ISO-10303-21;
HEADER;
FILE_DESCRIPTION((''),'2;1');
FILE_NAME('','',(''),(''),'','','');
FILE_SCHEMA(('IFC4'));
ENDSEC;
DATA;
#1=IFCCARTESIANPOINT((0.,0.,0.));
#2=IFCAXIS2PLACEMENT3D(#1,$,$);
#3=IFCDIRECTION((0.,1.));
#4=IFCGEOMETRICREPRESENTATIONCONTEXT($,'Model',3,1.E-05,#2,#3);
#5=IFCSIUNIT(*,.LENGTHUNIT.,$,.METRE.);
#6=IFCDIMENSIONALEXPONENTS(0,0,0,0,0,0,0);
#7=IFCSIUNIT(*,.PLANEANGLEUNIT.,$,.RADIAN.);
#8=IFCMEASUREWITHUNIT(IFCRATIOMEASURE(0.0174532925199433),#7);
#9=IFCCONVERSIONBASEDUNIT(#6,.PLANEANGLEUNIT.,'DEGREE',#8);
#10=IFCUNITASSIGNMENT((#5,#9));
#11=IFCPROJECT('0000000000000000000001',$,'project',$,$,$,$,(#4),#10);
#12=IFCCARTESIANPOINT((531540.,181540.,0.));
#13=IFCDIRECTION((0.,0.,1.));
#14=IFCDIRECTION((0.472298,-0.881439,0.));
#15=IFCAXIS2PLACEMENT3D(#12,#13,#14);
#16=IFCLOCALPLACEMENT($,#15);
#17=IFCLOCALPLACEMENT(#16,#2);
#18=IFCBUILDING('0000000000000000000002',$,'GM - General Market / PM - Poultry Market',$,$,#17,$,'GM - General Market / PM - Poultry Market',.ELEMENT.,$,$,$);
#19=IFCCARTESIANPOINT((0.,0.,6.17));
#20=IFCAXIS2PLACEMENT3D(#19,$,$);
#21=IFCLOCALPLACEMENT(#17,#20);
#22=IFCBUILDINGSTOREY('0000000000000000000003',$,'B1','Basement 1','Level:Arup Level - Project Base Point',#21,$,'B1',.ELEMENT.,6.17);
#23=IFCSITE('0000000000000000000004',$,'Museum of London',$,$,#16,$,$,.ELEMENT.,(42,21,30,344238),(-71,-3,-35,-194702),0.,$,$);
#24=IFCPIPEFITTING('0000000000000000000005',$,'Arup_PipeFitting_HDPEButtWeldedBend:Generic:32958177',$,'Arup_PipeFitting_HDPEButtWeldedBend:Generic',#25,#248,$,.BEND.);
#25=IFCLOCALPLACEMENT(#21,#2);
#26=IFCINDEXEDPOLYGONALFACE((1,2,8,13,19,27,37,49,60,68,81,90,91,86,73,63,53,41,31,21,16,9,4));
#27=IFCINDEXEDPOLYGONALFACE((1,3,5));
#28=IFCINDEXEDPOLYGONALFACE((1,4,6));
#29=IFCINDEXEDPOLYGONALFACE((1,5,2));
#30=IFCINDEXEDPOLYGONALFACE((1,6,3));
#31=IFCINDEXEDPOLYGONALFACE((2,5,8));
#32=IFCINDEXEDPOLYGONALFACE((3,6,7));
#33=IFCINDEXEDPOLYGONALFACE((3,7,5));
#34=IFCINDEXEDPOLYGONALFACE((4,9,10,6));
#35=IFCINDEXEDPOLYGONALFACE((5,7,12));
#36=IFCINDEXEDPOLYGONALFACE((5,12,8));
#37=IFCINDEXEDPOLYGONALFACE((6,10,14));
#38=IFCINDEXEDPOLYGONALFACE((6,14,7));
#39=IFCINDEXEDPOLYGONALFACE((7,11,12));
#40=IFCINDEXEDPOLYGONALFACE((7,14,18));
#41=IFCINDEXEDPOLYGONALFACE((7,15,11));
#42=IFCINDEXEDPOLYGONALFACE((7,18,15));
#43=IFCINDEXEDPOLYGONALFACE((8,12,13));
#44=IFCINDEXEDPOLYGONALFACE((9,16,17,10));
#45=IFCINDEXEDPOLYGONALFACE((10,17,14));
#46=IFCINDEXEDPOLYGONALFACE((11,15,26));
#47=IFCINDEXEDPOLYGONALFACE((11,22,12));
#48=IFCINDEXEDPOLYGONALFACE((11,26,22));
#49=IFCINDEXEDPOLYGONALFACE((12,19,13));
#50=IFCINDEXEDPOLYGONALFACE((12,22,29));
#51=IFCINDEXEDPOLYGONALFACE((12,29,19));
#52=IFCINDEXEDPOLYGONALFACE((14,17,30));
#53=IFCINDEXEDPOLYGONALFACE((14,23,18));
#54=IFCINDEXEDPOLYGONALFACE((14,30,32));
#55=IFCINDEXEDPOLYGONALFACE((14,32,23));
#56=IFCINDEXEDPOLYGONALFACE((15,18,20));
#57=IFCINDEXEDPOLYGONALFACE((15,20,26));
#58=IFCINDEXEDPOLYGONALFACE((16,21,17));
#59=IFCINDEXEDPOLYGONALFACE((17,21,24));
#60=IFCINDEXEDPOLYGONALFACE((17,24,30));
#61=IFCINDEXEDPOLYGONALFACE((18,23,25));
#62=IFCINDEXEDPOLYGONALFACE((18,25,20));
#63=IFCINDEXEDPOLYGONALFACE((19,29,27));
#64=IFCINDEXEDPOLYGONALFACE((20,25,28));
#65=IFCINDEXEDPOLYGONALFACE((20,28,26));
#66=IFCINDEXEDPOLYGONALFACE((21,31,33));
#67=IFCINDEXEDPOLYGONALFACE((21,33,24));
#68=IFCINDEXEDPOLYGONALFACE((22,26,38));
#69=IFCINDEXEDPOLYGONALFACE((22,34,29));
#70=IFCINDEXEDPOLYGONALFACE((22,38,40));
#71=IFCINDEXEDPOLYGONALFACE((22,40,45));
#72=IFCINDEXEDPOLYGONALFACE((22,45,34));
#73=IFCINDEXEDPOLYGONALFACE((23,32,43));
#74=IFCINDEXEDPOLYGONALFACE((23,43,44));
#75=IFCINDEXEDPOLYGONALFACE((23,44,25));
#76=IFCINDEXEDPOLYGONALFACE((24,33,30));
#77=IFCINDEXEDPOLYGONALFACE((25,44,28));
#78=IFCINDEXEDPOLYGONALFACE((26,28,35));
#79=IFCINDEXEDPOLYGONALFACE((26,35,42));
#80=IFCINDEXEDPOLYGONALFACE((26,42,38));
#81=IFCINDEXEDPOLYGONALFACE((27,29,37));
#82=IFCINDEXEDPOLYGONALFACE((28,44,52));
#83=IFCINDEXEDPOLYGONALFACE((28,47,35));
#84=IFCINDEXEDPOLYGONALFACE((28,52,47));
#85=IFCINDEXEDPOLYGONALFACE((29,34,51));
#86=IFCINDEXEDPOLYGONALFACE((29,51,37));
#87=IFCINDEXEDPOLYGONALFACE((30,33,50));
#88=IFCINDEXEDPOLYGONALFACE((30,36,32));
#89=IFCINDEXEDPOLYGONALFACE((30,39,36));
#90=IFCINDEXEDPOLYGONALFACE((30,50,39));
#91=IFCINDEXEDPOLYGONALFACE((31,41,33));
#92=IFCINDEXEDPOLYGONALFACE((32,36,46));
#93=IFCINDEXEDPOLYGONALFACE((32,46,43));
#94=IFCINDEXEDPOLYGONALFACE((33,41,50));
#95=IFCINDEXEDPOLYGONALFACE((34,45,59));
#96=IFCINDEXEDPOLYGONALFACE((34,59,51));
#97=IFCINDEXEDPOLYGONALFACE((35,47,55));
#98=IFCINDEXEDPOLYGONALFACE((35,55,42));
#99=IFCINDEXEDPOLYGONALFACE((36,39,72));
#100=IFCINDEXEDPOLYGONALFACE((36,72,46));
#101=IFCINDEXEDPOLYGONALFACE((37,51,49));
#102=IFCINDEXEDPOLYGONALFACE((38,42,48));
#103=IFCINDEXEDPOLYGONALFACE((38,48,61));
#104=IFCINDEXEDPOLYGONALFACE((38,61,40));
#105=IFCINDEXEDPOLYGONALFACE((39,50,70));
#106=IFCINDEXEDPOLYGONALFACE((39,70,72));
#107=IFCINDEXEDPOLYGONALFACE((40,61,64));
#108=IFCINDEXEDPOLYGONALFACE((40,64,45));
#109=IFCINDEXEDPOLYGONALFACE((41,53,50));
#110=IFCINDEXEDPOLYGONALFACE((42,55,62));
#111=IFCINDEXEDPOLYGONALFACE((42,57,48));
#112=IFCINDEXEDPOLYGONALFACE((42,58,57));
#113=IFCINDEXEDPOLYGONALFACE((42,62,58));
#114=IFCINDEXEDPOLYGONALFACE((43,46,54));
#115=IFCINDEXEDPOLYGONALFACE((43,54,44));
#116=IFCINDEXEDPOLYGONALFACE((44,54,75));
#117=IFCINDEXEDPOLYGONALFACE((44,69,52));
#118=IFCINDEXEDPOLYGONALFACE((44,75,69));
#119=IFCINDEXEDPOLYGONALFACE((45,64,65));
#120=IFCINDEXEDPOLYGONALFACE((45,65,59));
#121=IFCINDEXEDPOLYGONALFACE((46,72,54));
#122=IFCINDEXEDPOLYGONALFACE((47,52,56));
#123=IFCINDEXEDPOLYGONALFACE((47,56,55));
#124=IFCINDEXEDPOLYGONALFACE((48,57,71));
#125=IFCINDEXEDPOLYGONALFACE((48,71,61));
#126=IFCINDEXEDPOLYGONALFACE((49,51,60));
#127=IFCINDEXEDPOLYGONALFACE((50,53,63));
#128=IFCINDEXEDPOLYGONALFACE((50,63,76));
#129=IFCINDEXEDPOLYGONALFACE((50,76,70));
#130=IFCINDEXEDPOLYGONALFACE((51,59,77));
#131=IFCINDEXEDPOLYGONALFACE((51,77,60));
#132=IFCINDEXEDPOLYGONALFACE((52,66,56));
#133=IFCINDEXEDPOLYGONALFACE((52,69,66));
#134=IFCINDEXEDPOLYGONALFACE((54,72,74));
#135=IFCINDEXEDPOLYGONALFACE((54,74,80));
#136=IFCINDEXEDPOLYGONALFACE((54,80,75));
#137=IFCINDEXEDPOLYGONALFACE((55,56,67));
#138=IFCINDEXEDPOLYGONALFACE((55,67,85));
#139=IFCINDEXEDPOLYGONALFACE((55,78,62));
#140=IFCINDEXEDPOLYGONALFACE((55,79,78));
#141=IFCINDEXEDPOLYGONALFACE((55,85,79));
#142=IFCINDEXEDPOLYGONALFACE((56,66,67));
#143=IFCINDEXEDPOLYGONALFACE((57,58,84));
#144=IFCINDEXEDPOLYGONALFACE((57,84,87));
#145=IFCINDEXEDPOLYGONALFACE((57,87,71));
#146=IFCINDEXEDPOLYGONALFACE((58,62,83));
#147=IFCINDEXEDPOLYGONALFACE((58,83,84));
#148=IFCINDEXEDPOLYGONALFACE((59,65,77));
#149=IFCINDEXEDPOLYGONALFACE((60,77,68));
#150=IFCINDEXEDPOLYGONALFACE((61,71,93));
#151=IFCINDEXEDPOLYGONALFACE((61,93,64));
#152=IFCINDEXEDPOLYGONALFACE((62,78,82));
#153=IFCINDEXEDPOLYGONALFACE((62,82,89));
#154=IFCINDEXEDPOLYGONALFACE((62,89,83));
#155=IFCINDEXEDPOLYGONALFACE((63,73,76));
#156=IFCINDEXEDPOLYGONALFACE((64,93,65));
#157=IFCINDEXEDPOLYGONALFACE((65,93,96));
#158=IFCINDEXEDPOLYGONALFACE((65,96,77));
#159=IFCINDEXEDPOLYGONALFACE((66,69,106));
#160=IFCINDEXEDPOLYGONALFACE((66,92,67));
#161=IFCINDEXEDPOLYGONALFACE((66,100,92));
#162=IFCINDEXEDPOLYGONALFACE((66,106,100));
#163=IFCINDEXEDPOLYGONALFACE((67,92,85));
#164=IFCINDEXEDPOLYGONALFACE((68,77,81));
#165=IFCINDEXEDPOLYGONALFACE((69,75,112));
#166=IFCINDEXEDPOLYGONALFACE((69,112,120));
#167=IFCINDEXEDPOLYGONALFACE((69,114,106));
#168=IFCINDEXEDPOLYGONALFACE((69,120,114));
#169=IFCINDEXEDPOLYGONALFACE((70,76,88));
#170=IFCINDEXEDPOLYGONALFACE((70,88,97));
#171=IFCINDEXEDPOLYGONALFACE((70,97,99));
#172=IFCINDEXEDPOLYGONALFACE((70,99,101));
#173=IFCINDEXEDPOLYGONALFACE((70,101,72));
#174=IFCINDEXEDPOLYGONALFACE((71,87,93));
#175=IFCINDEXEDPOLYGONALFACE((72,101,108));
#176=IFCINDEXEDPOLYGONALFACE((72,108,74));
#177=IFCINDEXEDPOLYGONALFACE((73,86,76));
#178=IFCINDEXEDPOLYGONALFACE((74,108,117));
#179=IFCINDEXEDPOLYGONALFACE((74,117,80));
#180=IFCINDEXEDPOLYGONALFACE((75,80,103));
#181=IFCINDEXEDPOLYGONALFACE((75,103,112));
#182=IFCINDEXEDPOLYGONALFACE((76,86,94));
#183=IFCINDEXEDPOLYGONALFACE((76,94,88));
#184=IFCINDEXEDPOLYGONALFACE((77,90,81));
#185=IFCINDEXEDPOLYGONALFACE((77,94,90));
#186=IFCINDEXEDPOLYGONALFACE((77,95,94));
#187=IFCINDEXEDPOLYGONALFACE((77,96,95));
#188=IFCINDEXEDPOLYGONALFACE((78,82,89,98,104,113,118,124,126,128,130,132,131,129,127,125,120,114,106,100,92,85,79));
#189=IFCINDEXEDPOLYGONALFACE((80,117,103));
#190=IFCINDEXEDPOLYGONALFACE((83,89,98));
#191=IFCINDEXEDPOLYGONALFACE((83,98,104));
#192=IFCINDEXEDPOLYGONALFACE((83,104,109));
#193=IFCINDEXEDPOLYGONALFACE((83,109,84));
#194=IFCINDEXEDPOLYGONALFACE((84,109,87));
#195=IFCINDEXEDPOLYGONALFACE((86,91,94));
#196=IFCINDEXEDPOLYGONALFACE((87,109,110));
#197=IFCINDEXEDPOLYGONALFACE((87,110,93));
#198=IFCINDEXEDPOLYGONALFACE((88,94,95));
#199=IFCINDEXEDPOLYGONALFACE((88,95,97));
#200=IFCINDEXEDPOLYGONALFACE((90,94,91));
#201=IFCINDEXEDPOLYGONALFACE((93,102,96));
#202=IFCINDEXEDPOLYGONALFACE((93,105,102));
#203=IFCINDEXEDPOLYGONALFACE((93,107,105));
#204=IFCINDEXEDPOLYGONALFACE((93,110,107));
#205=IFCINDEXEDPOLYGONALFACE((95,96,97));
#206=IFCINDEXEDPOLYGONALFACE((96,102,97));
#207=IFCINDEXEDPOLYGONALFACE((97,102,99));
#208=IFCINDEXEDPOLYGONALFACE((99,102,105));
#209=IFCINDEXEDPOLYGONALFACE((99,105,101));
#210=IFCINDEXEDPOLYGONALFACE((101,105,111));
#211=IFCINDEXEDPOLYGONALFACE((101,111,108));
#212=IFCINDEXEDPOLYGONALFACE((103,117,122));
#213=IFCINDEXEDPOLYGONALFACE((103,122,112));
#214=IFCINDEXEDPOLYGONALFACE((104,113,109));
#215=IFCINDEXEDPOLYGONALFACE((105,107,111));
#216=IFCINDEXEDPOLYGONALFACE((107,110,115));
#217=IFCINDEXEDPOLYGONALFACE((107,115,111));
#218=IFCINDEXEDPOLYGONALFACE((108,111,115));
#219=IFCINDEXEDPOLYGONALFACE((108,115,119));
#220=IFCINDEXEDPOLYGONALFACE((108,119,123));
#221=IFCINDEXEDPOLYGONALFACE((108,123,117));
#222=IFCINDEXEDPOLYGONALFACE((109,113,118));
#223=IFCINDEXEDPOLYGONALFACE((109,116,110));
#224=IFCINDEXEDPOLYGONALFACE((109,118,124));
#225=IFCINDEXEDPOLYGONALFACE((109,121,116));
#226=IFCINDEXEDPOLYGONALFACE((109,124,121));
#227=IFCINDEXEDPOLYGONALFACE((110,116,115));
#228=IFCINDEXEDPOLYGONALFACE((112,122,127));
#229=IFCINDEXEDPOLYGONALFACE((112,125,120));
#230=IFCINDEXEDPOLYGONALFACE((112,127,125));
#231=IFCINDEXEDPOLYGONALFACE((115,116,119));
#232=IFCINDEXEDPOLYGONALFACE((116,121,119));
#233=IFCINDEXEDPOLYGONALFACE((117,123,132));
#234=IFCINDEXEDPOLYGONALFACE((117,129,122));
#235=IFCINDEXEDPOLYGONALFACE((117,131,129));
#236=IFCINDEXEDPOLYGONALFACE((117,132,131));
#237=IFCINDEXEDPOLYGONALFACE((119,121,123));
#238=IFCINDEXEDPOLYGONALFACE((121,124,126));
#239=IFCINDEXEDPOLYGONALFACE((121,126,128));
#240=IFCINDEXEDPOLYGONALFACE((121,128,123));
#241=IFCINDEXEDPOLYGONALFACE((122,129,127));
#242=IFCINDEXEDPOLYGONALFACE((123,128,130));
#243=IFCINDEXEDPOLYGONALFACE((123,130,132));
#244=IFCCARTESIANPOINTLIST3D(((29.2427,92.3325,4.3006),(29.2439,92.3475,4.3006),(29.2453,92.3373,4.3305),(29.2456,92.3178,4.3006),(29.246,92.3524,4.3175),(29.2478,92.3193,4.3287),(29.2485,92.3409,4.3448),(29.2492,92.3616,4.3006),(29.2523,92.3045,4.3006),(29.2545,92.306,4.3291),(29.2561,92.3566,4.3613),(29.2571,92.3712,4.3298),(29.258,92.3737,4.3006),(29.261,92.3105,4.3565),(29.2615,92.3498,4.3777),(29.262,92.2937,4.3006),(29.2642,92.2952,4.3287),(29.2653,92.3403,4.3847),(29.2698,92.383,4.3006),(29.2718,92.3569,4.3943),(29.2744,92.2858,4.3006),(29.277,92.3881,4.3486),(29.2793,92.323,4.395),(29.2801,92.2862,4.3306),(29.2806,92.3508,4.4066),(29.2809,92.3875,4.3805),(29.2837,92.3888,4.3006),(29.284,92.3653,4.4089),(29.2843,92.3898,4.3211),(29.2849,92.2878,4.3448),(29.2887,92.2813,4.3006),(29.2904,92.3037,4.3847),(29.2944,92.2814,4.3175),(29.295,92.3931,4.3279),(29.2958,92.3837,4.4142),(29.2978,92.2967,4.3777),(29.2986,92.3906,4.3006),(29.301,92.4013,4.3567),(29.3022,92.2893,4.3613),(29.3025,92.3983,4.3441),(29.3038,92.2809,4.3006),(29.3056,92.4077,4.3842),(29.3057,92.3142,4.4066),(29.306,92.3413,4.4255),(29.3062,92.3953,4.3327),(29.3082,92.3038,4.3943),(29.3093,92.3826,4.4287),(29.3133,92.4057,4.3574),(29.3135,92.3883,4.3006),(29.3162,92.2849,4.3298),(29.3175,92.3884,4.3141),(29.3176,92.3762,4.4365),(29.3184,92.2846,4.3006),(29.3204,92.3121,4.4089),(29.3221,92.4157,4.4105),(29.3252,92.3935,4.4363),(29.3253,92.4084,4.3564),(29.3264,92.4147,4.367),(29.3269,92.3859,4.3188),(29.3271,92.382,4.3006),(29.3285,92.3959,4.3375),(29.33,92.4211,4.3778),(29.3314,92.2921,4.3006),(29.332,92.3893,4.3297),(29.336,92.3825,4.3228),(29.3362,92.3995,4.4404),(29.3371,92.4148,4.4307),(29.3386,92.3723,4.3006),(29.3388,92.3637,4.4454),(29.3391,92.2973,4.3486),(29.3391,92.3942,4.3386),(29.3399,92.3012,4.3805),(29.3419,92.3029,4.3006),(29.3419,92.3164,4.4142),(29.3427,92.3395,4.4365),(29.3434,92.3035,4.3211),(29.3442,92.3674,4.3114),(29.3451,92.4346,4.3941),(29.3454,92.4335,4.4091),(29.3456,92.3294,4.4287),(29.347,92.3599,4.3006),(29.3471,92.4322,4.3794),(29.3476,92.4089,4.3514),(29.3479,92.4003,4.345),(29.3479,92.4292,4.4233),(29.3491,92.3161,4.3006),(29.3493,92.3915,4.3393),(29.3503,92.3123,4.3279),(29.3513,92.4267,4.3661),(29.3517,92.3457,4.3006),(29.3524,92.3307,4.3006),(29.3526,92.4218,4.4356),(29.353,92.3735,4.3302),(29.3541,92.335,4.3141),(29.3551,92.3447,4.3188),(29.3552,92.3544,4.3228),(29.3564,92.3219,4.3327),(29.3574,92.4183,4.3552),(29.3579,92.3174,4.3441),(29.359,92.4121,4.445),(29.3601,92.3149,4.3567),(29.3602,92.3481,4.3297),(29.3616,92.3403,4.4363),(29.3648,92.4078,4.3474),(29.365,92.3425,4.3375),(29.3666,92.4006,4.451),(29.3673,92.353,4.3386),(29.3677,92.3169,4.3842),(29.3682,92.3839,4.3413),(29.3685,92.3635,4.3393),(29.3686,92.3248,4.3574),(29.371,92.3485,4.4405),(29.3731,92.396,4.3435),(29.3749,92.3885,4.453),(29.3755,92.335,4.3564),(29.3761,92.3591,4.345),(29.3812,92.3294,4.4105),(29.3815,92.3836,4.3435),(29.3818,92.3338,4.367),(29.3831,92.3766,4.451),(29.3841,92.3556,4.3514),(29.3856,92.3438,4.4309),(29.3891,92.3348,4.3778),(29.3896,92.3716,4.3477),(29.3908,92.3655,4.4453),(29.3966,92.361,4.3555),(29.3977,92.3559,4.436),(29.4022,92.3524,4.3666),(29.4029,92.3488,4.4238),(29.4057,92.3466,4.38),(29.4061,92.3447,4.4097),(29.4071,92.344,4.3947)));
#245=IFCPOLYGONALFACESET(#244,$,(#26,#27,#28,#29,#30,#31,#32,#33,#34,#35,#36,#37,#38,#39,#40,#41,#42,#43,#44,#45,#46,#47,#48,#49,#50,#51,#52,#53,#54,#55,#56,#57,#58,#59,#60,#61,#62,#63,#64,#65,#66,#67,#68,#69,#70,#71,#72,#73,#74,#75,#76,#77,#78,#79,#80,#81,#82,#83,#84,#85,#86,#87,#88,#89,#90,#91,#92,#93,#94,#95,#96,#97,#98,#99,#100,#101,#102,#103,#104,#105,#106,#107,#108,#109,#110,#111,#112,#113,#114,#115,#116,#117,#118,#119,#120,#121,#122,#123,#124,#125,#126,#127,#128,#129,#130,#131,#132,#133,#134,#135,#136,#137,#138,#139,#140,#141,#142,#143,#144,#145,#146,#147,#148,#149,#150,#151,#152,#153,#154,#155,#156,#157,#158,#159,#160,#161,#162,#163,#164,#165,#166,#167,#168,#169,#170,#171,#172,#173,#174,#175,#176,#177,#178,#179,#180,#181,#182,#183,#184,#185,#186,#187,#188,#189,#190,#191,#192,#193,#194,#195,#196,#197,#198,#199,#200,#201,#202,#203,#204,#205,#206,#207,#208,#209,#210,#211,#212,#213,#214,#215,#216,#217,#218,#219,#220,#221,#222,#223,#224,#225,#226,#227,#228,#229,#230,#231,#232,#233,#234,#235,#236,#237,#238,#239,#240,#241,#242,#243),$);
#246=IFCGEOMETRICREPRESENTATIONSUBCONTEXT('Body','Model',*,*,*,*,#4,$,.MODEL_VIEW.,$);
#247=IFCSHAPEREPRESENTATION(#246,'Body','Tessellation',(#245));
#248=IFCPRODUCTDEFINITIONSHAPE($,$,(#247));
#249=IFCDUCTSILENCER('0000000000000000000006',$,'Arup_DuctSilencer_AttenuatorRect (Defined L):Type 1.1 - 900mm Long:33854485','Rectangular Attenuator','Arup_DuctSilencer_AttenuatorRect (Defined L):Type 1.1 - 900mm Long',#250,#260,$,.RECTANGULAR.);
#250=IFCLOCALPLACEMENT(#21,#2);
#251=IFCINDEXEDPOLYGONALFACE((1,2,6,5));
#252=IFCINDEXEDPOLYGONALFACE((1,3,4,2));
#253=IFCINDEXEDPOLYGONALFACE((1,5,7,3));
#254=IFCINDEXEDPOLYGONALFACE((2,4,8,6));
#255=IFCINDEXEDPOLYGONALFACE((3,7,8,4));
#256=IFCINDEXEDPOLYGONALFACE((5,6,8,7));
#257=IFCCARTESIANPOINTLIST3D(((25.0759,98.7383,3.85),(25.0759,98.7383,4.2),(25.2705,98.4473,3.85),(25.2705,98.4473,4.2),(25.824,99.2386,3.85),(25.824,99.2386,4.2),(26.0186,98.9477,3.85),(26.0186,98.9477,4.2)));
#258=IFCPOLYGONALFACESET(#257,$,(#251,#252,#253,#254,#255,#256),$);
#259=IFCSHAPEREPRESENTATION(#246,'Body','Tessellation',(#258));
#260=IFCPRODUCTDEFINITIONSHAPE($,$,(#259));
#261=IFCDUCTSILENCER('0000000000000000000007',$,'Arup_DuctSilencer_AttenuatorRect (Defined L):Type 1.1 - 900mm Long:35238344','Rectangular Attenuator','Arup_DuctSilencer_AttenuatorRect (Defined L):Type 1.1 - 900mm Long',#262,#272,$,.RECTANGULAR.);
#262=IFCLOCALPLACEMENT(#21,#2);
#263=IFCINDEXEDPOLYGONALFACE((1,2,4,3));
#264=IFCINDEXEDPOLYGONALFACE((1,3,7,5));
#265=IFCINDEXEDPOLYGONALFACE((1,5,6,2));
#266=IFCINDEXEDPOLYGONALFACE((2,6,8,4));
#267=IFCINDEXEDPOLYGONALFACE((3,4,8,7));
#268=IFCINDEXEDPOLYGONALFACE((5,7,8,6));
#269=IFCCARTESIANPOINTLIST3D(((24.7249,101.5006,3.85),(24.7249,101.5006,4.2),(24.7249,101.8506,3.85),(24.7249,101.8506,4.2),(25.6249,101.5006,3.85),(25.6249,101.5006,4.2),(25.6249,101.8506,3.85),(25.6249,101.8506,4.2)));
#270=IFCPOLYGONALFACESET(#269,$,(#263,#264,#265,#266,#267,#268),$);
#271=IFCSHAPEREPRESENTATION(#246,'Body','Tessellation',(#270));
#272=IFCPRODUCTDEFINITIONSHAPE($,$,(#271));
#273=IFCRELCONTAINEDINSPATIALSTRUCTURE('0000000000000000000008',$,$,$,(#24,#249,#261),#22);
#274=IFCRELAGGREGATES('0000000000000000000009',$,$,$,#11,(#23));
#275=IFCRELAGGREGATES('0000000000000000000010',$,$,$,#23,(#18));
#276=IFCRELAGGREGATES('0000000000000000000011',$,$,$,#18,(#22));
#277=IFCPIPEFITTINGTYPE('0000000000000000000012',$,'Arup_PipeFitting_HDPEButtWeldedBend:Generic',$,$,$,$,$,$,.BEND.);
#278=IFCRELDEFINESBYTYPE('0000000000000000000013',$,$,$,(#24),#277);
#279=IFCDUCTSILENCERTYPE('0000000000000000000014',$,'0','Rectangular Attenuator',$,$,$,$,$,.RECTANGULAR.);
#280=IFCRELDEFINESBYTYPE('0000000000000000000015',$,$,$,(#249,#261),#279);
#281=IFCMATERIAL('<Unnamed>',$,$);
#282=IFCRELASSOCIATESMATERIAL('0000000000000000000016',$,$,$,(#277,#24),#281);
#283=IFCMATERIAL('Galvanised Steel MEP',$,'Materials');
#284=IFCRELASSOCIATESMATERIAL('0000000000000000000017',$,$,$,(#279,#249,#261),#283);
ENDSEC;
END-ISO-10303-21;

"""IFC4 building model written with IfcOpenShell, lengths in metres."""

from ifc_helpers import new_model, entity, si_unit, converted_unit, direction, frame, origin, origin_2d_with_axis, place, context, subcontext, project, spatial, rectangle, extrude, source, transform, mapped, material, type_object, type_shapes, element, save


model = new_model("IFC4")

# Units and contexts
model_context = context("Model", 3, precision=1e-05, world=origin(), true_north=direction((0.0, 1.0)))
body_context = subcontext(model_context, "Body", "Model", "MODEL_VIEW")
ifc_project = project(units=[si_unit("LENGTHUNIT", "METRE"), converted_unit("PLANEANGLEUNIT", "DEGREE", entity("IfcRatioMeasure", 0.0174532925199433), si_unit("PLANEANGLEUNIT", "RADIAN"), dimensions=[0, 0, 0, 0, 0, 0, 0])], contexts=[model_context])

# Site, building, storey
site_placement = place(None, frame((531540.0, 181540.0, 0.0), z_axis=(0.0, 0.0, 1.0), x_axis=(0.472298, -0.881439, 0.0)))
site = spatial("IfcSite", under=ifc_project, at=site_placement, Name="Museum of London", CompositionType="ELEMENT", RefLatitude=(42, 21, 30, 344238), RefLongitude=(-71, -3, -35, -194702), RefElevation=0.0)
building_placement = place(site_placement, origin())
building = spatial("IfcBuilding", under=site, at=building_placement, Name="GM - General Market / PM - Poultry Market", LongName="GM - General Market / PM - Poultry Market", CompositionType="ELEMENT")
storey_placement = place(building_placement, frame((0.0, 0.0, 6.17)))
storey = spatial("IfcBuildingStorey", under=building, at=storey_placement, Name="B1", Description="Basement 1", ObjectType="Level:Arup Level - Project Base Point", LongName="B1", CompositionType="ELEMENT", Elevation=6.17)

# Shared definitions
ifc_material_1 = material(Name="Galvanised Steel MEP", Category="Materials")

# Pipe fitting
ifc_material_2 = material(Name="<Unnamed>")
pipe_fitting_type_1 = type_object("IfcPipeFittingType", Name="Arup_PipeFitting_HDPEButtWeldedBend:Generic", PredefinedType="BEND", material=ifc_material_2)
ifc_direction_1 = entity("IfcDirection", [0.0, 0.0, 1.0])
trimmed_curve_1 = entity("IfcTrimmedCurve", entity("IfcCircle", entity("IfcAxis2Placement2D", entity("IfcCartesianPoint", [-0.0974, 0.0]), entity("IfcDirection", [0.0, 1.0])), 0.0974), [entity("IfcParameterValue", 270.0)], [entity("IfcParameterValue", 358.567904)], True, "PARAMETER")
shared_shape_1 = source(origin(), body_context, "Body", "AdvancedSweptSolid", [
    entity("IfcSurfaceCurveSweptAreaSolid", entity("IfcCircleProfileDef", "AREA", None, entity("IfcAxis2Placement2D", entity("IfcCartesianPoint", [0.0, 0.0]), entity("IfcDirection", [1.0, 0.0])), 0.055), entity("IfcAxis2Placement3D", entity("IfcCartesianPoint", [-0.095, 0.0, 0.0]), ifc_direction_1, entity("IfcDirection", [0.0, -1.0, 0.0])), trimmed_curve_1, 0.0, 88.5679, entity("IfcSurfaceOfLinearExtrusion", entity("IfcArbitraryOpenProfileDef", "CURVE", None, trimmed_curve_1), entity("IfcAxis2Placement3D", entity("IfcCartesianPoint", [0.0, 0.0, -0.3048])), ifc_direction_1, 1.0)),
])
type_shapes(pipe_fitting_type_1, [shared_shape_1])
pipe_fitting_1_placement = place(storey_placement, frame((29.2976, 92.3356, 4.3956), z_axis=(0.564893, -0.825164, 0.0), x_axis=(-0.824906, -0.564717, -0.024992)))
element("IfcPipeFitting", 1, at=pipe_fitting_1_placement, inside=storey, type_object=pipe_fitting_type_1, material=ifc_material_2, Name="Arup_PipeFitting_HDPEButtWeldedBend:Generic:32958177", ObjectType="Arup_PipeFitting_HDPEButtWeldedBend:Generic", PredefinedType="BEND", context=body_context, shape_type="MappedRepresentation", body=[
    mapped(shared_shape_1, transform((0.0, 0.0, 0.0), scale=1.0)),
])

# Duct silencers
duct_silencer_type = type_object("IfcDuctSilencerType", Name="0", Description="Rectangular Attenuator", PredefinedType="RECTANGULAR", material=ifc_material_1)
shared_shape_2 = source(origin(), body_context, "Body", "SweptSolid", [
    extrude(rectangle(XDim=0.9, YDim=0.35, at=origin_2d_with_axis()), frame((0.0, 0.0, -0.175), z_axis=(0.0, 0.0, 1.0), x_axis=(-1.0, 0.0, 0.0)), (0.0, 0.0, 1.0), 0.35),
])
type_shapes(duct_silencer_type, [shared_shape_2])
duct_silencer_1_placement = place(storey_placement, frame((25.5472, 98.843, 4.025), z_axis=(0.0, 0.0, -1.0), x_axis=(-0.831246, -0.555905, 0.0)))
element("IfcDuctSilencer", 2, at=duct_silencer_1_placement, inside=storey, type_object=duct_silencer_type, material=ifc_material_1, Name="Arup_DuctSilencer_AttenuatorRect (Defined L):Type 1.1 - 900mm Long:33854485", Description="Rectangular Attenuator", ObjectType="Arup_DuctSilencer_AttenuatorRect (Defined L):Type 1.1 - 900mm Long", PredefinedType="RECTANGULAR", context=body_context, shape_type="MappedRepresentation", body=[
    mapped(shared_shape_2, transform((0.0, 0.0, 0.0), scale=1.0)),
])
duct_silencer_2_placement = place(storey_placement, frame((25.1749, 101.6756, 4.025)))
element("IfcDuctSilencer", 3, at=duct_silencer_2_placement, inside=storey, type_object=duct_silencer_type, material=ifc_material_1, Name="Arup_DuctSilencer_AttenuatorRect (Defined L):Type 1.1 - 900mm Long:35238344", Description="Rectangular Attenuator", ObjectType="Arup_DuctSilencer_AttenuatorRect (Defined L):Type 1.1 - 900mm Long", PredefinedType="RECTANGULAR", context=body_context, shape_type="MappedRepresentation", body=[
    mapped(shared_shape_2, transform((0.0, 0.0, 0.0), scale=1.0)),
])

save(model, "model.ifc")
